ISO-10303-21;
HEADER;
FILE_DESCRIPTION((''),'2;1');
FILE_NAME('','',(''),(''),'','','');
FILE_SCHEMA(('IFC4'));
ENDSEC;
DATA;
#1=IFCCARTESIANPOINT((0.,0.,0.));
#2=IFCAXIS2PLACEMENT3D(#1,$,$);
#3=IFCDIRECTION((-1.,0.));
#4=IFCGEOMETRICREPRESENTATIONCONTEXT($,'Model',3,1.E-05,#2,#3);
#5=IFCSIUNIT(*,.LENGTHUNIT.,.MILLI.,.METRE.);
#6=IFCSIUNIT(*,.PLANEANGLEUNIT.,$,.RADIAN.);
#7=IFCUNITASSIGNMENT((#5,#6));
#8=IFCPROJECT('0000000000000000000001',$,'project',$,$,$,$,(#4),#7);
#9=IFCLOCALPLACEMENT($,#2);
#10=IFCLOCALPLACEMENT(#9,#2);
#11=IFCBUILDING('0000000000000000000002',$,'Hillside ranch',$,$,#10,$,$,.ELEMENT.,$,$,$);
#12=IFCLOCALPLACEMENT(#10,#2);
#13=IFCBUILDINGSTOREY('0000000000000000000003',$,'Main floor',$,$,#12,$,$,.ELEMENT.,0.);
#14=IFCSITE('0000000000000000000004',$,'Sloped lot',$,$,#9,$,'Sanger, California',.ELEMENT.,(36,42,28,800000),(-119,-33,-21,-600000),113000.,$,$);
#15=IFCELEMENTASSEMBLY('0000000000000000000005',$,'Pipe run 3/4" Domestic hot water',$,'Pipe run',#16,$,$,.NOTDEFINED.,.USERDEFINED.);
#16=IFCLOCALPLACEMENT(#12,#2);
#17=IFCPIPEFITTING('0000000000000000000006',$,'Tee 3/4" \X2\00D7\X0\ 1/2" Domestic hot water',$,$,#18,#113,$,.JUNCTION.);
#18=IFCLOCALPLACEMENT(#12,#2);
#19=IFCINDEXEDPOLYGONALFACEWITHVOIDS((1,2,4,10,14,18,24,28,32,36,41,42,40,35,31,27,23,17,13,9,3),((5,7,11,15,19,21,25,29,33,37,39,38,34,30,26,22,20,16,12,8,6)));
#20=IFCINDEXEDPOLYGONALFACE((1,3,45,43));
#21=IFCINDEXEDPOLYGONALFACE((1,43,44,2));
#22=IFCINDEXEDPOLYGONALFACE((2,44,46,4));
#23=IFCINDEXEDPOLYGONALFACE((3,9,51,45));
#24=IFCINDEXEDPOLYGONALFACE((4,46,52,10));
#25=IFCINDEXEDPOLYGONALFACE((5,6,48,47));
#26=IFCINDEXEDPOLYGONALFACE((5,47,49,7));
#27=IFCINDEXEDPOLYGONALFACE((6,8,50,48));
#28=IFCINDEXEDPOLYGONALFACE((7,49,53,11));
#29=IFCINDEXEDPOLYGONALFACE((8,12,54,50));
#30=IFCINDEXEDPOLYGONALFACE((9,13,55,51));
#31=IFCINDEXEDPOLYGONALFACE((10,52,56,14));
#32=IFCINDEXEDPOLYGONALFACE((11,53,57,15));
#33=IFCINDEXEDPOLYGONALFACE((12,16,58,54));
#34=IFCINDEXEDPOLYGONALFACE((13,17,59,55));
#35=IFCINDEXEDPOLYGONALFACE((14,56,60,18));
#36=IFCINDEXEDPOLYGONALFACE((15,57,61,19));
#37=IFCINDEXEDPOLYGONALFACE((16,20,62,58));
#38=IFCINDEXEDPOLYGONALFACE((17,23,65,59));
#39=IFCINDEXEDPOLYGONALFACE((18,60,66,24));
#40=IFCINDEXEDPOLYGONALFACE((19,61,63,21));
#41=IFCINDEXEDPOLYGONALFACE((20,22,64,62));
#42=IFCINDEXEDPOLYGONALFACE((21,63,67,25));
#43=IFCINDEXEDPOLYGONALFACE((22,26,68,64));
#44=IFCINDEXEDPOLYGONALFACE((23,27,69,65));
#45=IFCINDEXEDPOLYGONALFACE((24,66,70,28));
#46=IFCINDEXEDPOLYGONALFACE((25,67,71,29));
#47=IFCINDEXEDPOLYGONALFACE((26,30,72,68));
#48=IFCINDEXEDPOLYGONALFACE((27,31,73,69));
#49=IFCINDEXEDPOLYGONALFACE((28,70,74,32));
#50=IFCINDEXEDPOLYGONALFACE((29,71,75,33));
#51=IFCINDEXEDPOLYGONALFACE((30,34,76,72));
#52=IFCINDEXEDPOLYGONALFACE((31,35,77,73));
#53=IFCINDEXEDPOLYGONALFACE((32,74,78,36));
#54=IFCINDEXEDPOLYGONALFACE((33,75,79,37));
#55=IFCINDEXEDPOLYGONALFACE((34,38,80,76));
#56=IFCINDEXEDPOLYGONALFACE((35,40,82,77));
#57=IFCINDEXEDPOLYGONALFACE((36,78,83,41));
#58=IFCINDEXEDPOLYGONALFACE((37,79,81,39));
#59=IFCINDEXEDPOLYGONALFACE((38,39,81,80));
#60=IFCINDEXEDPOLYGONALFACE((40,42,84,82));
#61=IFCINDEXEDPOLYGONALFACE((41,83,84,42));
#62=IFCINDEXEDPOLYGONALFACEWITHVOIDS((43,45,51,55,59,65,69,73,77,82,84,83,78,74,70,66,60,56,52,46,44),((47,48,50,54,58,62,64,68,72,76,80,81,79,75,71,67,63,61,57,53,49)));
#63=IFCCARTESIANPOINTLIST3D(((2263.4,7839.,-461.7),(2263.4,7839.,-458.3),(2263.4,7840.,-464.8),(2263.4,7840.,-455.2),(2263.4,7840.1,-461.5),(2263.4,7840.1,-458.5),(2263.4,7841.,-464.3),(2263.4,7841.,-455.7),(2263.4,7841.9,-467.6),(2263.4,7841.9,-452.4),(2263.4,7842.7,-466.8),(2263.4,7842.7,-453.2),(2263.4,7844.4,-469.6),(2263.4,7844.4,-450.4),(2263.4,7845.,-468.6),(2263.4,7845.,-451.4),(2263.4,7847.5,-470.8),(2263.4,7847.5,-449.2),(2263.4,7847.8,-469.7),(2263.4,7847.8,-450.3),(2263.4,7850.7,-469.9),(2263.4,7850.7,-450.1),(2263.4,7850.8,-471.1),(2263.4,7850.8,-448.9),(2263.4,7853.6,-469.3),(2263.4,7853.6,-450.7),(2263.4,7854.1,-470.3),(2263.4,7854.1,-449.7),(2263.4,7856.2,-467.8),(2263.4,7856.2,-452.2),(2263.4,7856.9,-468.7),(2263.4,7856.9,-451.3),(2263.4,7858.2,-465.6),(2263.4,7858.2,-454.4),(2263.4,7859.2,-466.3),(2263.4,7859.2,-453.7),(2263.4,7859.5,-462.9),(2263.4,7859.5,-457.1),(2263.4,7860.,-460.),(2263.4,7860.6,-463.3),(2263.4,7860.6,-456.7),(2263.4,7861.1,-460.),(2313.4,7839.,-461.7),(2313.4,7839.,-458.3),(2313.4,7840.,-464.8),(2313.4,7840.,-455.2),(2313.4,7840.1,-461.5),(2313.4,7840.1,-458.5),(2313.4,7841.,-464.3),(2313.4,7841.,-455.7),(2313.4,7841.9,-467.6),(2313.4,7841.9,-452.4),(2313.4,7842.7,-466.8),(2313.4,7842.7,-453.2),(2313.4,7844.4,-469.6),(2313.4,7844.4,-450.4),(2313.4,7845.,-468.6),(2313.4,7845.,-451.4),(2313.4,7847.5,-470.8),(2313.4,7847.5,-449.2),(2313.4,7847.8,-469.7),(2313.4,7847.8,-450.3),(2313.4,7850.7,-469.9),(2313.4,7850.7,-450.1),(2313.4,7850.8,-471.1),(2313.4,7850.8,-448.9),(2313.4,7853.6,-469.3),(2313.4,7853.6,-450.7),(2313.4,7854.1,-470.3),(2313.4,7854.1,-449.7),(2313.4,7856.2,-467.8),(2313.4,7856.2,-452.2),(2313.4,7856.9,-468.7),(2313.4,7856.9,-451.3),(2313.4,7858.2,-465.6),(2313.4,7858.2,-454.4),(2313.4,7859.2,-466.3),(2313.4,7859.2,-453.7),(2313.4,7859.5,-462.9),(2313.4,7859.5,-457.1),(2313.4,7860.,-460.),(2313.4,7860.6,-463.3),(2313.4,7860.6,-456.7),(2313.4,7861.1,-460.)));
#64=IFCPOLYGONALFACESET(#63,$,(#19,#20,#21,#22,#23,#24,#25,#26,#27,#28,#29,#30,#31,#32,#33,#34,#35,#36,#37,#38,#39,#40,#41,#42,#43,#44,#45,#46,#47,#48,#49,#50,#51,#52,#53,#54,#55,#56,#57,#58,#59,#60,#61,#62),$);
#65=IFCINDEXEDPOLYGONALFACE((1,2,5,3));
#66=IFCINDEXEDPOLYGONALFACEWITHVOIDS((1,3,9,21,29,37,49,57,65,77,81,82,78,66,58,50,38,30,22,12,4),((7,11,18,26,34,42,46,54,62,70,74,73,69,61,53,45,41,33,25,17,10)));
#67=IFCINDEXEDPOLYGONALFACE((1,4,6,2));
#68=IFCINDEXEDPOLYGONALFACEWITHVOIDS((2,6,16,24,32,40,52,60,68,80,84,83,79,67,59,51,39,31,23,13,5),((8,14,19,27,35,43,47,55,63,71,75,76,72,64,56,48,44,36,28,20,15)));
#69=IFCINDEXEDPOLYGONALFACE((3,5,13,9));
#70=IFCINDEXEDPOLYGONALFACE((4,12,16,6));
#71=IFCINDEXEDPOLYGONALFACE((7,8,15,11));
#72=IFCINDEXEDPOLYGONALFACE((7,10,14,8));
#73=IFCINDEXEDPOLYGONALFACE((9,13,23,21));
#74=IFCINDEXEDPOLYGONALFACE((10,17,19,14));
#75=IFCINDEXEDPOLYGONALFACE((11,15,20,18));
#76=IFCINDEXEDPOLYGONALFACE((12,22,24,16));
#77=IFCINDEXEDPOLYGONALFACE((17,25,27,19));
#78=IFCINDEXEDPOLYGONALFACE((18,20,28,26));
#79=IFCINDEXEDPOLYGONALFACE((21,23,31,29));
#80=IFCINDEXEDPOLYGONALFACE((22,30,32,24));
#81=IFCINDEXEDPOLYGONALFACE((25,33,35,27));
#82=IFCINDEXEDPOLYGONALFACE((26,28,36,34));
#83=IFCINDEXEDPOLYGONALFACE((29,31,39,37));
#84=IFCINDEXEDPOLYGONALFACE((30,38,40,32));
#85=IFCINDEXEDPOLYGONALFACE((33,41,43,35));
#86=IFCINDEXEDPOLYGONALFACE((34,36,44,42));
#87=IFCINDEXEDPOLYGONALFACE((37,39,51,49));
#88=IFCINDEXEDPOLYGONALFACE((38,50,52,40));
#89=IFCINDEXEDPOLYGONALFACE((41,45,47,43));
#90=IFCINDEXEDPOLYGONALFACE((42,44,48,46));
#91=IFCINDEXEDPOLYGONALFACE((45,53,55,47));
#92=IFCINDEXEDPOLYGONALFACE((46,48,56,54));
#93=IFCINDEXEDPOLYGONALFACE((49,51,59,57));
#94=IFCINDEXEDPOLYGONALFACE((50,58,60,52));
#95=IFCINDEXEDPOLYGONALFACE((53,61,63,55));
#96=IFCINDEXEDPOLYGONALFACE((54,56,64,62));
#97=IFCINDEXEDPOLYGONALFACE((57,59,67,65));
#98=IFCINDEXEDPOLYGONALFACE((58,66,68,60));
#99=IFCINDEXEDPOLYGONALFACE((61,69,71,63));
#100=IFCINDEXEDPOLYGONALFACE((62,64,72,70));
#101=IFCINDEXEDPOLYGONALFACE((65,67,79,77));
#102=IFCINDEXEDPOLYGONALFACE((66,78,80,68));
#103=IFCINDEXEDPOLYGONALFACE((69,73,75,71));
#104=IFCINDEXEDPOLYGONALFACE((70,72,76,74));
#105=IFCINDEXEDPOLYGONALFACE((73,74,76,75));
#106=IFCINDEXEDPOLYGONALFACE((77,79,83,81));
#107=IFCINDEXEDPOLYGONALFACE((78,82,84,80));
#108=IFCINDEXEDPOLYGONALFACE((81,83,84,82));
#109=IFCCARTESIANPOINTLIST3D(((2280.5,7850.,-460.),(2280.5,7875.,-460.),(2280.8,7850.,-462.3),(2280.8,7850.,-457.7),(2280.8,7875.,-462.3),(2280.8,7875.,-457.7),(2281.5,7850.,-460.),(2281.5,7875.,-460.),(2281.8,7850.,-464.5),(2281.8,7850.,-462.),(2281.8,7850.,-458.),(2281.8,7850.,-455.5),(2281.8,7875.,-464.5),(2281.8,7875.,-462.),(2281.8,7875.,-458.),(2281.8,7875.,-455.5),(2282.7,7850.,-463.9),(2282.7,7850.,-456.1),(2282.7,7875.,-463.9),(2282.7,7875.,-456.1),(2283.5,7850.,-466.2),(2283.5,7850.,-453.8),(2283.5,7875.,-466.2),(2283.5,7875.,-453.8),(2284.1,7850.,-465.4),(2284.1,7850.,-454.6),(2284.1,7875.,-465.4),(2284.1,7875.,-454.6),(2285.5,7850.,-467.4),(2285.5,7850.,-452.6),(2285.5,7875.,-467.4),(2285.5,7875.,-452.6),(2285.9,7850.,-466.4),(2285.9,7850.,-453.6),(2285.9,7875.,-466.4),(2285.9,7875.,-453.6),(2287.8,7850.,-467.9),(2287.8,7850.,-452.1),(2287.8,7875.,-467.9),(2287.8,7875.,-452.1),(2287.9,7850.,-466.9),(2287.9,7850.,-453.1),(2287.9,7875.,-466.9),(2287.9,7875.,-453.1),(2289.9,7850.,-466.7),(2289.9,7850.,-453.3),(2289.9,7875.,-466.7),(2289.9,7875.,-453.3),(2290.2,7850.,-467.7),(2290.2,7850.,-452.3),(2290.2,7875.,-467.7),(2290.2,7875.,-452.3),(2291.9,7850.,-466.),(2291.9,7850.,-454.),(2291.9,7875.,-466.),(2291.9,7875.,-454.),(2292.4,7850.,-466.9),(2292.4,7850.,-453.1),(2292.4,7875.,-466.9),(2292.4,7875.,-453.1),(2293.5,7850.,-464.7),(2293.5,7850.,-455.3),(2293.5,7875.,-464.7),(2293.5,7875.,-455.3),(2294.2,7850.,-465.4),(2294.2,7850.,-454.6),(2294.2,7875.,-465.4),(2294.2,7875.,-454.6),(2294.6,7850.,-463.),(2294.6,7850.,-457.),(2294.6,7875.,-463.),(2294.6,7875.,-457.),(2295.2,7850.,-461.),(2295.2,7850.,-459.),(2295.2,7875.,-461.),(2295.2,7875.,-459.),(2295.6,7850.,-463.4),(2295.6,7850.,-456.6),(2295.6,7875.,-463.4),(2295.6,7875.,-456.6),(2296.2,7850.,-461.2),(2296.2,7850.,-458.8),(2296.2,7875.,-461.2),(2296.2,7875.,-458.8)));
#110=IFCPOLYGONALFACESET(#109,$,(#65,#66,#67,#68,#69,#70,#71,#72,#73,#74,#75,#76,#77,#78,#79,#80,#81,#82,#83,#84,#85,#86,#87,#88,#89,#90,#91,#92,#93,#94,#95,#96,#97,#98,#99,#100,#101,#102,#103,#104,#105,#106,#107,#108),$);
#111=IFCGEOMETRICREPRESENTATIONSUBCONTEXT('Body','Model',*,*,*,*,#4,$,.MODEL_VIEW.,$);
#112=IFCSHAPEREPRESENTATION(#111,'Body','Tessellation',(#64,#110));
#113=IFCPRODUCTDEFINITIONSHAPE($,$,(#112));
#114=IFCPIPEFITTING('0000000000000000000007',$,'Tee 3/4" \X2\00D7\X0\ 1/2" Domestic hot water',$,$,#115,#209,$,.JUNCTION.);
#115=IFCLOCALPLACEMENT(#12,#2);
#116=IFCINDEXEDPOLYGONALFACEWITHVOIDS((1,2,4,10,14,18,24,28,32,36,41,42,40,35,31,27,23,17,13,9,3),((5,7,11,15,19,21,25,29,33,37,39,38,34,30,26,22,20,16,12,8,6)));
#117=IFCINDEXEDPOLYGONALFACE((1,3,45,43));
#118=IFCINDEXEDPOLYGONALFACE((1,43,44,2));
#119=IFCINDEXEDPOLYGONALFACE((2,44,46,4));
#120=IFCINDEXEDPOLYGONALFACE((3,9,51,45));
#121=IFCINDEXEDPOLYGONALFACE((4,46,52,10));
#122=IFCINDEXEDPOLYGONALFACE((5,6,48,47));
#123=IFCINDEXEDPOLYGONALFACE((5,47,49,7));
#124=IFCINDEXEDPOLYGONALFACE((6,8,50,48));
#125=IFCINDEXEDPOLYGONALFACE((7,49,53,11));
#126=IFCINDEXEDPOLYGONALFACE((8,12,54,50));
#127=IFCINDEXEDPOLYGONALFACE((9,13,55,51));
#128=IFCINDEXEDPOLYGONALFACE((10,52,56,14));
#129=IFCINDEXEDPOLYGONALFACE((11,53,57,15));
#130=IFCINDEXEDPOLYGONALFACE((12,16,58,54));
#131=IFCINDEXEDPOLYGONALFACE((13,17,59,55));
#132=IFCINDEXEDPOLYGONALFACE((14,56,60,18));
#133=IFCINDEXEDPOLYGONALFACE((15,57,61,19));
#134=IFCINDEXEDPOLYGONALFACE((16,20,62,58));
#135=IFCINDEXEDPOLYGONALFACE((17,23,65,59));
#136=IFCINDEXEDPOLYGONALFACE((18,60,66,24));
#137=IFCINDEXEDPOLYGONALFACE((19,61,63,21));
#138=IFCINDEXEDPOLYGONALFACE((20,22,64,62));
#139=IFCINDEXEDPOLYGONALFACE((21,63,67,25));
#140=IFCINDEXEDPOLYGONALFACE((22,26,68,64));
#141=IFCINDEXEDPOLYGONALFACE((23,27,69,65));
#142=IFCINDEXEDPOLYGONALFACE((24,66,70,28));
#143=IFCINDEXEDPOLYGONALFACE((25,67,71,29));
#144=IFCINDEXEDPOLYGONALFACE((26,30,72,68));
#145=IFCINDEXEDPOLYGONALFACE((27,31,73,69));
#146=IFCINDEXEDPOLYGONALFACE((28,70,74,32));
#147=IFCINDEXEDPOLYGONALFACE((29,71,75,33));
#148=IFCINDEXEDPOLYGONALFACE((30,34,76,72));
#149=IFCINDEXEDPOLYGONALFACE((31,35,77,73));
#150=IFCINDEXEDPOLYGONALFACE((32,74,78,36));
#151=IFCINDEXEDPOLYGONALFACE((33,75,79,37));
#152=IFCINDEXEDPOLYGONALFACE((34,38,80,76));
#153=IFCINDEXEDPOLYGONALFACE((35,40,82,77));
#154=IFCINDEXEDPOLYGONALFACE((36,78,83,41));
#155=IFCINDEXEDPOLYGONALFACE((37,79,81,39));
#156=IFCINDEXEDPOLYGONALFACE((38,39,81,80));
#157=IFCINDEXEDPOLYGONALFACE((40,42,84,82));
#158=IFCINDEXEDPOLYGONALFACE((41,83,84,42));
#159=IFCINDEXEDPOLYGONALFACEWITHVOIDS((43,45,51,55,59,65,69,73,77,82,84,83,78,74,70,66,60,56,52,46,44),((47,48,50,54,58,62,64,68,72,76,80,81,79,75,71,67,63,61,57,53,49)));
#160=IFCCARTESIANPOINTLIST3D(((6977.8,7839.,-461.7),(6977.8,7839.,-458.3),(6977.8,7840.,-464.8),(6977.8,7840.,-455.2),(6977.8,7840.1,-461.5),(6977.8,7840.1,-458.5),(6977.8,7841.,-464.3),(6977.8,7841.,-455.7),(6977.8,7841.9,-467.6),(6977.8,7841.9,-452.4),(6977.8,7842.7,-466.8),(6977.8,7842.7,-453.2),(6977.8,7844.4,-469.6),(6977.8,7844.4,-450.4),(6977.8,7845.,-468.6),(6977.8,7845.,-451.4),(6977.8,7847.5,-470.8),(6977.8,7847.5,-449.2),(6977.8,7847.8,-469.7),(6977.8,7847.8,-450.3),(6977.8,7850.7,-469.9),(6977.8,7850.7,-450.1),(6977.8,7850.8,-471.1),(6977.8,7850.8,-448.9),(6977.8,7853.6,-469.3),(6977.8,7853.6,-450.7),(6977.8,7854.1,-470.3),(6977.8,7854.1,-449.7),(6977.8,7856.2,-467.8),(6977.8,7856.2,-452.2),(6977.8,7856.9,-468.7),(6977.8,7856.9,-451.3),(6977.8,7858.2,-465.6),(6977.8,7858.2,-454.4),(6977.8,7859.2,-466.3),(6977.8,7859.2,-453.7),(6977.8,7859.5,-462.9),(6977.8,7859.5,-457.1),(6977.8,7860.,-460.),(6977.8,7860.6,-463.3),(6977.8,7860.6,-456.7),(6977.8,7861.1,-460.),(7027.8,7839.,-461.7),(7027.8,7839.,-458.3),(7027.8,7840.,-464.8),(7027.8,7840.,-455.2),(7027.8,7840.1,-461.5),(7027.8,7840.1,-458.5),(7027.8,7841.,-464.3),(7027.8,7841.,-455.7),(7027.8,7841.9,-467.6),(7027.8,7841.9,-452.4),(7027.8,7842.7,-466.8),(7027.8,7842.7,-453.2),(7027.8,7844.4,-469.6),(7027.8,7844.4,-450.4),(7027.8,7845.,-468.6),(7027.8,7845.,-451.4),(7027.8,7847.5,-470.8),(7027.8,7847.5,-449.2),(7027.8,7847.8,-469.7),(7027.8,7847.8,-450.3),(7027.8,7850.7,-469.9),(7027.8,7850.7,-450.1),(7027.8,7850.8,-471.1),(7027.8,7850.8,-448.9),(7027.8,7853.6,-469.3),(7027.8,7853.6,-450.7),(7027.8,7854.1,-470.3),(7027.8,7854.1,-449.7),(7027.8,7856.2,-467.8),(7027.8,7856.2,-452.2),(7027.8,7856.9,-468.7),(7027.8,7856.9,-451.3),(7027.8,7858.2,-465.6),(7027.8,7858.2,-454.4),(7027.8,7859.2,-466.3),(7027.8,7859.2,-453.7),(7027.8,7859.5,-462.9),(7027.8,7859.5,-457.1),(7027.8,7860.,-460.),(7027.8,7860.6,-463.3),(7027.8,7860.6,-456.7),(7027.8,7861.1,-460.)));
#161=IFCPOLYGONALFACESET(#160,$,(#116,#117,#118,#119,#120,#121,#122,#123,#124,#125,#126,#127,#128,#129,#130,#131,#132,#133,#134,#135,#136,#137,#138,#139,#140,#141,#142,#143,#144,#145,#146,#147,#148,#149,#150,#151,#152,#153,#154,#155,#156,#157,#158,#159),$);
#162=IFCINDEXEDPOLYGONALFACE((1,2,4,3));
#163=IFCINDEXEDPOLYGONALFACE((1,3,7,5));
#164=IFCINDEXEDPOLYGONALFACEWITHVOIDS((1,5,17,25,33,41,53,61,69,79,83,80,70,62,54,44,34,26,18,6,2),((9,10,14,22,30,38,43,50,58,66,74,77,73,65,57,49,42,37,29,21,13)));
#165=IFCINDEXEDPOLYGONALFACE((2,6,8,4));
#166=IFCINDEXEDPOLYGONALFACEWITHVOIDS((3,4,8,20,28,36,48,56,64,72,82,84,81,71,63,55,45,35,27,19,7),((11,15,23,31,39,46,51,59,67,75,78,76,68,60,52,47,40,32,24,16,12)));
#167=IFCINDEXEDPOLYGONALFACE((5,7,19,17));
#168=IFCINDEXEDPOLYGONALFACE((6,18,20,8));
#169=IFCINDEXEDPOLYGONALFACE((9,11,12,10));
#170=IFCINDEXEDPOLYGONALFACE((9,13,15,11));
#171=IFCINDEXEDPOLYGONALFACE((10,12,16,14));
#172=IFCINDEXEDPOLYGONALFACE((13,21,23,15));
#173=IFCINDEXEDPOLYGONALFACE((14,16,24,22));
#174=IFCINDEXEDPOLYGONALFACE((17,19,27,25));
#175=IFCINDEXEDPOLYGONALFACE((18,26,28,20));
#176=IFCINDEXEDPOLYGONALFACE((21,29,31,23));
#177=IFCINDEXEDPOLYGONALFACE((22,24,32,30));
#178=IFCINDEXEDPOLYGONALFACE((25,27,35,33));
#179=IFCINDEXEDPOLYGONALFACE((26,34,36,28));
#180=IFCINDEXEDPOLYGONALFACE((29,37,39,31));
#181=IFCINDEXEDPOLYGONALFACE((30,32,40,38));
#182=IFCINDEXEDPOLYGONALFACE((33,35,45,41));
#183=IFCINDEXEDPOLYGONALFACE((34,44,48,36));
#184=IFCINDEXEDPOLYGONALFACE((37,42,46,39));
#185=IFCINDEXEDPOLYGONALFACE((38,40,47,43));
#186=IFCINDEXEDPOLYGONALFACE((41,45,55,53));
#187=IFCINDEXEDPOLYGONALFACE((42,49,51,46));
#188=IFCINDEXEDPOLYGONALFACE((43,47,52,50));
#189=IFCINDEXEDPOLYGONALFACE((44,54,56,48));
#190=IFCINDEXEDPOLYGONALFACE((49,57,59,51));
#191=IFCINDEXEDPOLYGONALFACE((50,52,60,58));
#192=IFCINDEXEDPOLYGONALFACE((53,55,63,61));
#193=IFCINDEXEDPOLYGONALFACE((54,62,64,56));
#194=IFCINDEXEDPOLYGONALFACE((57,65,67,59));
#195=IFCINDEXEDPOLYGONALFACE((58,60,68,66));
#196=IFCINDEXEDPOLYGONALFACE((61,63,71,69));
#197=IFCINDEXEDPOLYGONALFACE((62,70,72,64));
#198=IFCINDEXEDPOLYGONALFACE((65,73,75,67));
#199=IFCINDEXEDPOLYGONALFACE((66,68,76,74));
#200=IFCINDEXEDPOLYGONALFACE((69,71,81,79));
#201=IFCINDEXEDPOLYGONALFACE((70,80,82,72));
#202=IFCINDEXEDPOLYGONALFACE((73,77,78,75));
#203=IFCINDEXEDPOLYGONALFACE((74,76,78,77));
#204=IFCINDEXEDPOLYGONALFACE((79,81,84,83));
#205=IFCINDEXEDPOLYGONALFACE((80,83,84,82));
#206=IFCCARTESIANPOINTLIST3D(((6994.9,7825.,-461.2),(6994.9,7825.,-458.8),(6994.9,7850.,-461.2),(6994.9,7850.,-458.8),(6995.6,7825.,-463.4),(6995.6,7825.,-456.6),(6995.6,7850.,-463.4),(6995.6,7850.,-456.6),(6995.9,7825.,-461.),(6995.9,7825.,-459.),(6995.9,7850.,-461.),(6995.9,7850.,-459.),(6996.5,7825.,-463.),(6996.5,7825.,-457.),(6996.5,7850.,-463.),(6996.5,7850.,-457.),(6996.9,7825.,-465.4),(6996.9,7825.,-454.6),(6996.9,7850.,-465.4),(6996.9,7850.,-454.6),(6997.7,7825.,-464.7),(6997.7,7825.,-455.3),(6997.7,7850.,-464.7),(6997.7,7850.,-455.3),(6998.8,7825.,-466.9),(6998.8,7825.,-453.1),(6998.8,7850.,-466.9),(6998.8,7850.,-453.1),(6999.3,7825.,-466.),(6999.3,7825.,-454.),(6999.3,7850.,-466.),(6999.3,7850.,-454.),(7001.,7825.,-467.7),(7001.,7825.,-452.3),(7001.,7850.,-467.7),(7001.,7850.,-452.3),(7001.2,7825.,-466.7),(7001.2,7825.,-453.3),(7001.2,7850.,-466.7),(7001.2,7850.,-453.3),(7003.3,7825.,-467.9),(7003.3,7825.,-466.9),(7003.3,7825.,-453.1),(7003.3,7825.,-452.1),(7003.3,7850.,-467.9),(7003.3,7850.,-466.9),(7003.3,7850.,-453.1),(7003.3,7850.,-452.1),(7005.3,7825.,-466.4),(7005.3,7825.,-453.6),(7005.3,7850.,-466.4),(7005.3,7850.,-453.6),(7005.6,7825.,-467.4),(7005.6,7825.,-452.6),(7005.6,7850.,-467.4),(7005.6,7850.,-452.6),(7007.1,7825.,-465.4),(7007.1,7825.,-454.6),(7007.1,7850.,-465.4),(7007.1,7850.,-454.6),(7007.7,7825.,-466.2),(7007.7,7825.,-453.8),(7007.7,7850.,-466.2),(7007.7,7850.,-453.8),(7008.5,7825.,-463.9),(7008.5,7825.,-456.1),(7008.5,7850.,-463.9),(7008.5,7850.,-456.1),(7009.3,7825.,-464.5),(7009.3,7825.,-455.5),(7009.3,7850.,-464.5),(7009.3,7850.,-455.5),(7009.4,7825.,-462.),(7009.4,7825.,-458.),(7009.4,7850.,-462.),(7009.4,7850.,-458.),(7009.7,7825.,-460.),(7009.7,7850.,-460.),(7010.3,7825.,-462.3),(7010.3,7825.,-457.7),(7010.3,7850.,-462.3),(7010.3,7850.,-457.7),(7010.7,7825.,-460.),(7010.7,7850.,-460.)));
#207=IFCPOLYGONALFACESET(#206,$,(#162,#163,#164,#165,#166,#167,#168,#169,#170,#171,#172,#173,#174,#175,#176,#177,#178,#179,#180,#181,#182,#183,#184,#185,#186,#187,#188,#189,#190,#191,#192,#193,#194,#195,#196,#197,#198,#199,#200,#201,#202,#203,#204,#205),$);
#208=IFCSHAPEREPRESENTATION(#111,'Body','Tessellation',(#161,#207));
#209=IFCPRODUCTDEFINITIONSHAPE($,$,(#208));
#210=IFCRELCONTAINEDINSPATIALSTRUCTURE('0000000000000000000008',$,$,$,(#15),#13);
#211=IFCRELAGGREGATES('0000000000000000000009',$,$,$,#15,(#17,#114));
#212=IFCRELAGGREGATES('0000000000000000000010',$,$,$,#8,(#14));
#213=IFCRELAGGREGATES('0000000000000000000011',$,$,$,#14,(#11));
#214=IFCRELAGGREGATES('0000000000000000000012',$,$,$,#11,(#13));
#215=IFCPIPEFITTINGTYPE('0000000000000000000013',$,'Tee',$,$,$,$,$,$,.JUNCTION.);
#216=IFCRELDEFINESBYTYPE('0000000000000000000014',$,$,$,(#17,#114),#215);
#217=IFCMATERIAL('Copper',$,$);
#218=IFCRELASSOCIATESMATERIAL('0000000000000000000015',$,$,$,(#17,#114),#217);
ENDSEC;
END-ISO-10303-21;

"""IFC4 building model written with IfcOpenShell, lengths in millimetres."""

from ifc_helpers import new_model, si_unit, direction, frame, origin, origin_with_axes, origin_2d, place, context, subcontext, project, spatial, hollow_circle, extrude, material, type_object, element, aggregate, save


model = new_model("IFC4")

# Units and contexts
model_context = context("Model", 3, precision=1e-05, world=origin(), true_north=direction((-1.0, 0.0)))
body_context = subcontext(model_context, "Body", "Model", "MODEL_VIEW")
ifc_project = project(units=[si_unit("LENGTHUNIT", "METRE", prefix="MILLI"), si_unit("PLANEANGLEUNIT", "RADIAN")], contexts=[model_context])

# Site, building, storey
site_placement = place(None, origin())
site = spatial("IfcSite", under=ifc_project, at=site_placement, Name="Sloped lot", LongName="Sanger, California", CompositionType="ELEMENT", RefLatitude=(36, 42, 28, 800000), RefLongitude=(-119, -33, -21, -600000), RefElevation=113000.0)
building_placement = place(site_placement, origin())
building = spatial("IfcBuilding", under=site, at=building_placement, Name="Hillside ranch", CompositionType="ELEMENT")
storey_placement = place(building_placement, origin())
storey = spatial("IfcBuildingStorey", under=building, at=storey_placement, Name="Main floor", CompositionType="ELEMENT", Elevation=0.0)

# Element assembly, pipe fittings
ifc_material = material(Name="Copper")
pipe_fitting_type_1 = type_object("IfcPipeFittingType", Name="Tee", PredefinedType="JUNCTION")
assembly_1_placement = place(storey_placement, origin_with_axes())
assembly_1 = element("IfcElementAssembly", 1, at=assembly_1_placement, inside=storey, Name="Pipe run 3/4\" Domestic hot water", ObjectType="Pipe run", AssemblyPlace="NOTDEFINED", PredefinedType="USERDEFINED")
pipe_fitting_1_placement = place(storey_placement, origin_with_axes())
pipe_fitting_1 = element("IfcPipeFitting", 2, at=pipe_fitting_1_placement, type_object=pipe_fitting_type_1, material=ifc_material, Name="Tee 3/4\" × 1/2\" Domestic hot water", PredefinedType="JUNCTION", context=body_context, shape_type="SweptSolid", body=[
    extrude(hollow_circle(Radius=11.1, WallThickness=1.1, at=origin_2d()), frame((2263.4, 7850.0, -460.0), z_axis=(1.0, 0.0, 0.0), x_axis=(0.0, 1.0, 0.0)), (0.0, 0.0, 1.0), 50.0),
    extrude(hollow_circle(Radius=7.9, WallThickness=1.0, at=origin_2d()), frame((2288.4, 7850.0, -460.0), z_axis=(0.0, 1.0, 0.0), x_axis=(-1.0, 0.0, 0.0)), (0.0, 0.0, 1.0), 25.0),
])
pipe_fitting_2_placement = place(storey_placement, origin_with_axes())
pipe_fitting_2 = element("IfcPipeFitting", 3, at=pipe_fitting_2_placement, type_object=pipe_fitting_type_1, material=ifc_material, Name="Tee 3/4\" × 1/2\" Domestic hot water", PredefinedType="JUNCTION", context=body_context, shape_type="SweptSolid", body=[
    extrude(hollow_circle(Radius=11.1, WallThickness=1.1, at=origin_2d()), frame((6977.8, 7850.0, -460.0), z_axis=(1.0, 0.0, 0.0), x_axis=(0.0, 1.0, 0.0)), (0.0, 0.0, 1.0), 50.0),
    extrude(hollow_circle(Radius=7.9, WallThickness=1.0, at=origin_2d()), frame((7002.8, 7850.0, -460.0), z_axis=(0.0, -1.0, 0.0), x_axis=(1.0, 0.0, 0.0)), (0.0, 0.0, 1.0), 25.0),
])

aggregate(assembly_1, [pipe_fitting_1, pipe_fitting_2])

save(model, "model.ifc")
